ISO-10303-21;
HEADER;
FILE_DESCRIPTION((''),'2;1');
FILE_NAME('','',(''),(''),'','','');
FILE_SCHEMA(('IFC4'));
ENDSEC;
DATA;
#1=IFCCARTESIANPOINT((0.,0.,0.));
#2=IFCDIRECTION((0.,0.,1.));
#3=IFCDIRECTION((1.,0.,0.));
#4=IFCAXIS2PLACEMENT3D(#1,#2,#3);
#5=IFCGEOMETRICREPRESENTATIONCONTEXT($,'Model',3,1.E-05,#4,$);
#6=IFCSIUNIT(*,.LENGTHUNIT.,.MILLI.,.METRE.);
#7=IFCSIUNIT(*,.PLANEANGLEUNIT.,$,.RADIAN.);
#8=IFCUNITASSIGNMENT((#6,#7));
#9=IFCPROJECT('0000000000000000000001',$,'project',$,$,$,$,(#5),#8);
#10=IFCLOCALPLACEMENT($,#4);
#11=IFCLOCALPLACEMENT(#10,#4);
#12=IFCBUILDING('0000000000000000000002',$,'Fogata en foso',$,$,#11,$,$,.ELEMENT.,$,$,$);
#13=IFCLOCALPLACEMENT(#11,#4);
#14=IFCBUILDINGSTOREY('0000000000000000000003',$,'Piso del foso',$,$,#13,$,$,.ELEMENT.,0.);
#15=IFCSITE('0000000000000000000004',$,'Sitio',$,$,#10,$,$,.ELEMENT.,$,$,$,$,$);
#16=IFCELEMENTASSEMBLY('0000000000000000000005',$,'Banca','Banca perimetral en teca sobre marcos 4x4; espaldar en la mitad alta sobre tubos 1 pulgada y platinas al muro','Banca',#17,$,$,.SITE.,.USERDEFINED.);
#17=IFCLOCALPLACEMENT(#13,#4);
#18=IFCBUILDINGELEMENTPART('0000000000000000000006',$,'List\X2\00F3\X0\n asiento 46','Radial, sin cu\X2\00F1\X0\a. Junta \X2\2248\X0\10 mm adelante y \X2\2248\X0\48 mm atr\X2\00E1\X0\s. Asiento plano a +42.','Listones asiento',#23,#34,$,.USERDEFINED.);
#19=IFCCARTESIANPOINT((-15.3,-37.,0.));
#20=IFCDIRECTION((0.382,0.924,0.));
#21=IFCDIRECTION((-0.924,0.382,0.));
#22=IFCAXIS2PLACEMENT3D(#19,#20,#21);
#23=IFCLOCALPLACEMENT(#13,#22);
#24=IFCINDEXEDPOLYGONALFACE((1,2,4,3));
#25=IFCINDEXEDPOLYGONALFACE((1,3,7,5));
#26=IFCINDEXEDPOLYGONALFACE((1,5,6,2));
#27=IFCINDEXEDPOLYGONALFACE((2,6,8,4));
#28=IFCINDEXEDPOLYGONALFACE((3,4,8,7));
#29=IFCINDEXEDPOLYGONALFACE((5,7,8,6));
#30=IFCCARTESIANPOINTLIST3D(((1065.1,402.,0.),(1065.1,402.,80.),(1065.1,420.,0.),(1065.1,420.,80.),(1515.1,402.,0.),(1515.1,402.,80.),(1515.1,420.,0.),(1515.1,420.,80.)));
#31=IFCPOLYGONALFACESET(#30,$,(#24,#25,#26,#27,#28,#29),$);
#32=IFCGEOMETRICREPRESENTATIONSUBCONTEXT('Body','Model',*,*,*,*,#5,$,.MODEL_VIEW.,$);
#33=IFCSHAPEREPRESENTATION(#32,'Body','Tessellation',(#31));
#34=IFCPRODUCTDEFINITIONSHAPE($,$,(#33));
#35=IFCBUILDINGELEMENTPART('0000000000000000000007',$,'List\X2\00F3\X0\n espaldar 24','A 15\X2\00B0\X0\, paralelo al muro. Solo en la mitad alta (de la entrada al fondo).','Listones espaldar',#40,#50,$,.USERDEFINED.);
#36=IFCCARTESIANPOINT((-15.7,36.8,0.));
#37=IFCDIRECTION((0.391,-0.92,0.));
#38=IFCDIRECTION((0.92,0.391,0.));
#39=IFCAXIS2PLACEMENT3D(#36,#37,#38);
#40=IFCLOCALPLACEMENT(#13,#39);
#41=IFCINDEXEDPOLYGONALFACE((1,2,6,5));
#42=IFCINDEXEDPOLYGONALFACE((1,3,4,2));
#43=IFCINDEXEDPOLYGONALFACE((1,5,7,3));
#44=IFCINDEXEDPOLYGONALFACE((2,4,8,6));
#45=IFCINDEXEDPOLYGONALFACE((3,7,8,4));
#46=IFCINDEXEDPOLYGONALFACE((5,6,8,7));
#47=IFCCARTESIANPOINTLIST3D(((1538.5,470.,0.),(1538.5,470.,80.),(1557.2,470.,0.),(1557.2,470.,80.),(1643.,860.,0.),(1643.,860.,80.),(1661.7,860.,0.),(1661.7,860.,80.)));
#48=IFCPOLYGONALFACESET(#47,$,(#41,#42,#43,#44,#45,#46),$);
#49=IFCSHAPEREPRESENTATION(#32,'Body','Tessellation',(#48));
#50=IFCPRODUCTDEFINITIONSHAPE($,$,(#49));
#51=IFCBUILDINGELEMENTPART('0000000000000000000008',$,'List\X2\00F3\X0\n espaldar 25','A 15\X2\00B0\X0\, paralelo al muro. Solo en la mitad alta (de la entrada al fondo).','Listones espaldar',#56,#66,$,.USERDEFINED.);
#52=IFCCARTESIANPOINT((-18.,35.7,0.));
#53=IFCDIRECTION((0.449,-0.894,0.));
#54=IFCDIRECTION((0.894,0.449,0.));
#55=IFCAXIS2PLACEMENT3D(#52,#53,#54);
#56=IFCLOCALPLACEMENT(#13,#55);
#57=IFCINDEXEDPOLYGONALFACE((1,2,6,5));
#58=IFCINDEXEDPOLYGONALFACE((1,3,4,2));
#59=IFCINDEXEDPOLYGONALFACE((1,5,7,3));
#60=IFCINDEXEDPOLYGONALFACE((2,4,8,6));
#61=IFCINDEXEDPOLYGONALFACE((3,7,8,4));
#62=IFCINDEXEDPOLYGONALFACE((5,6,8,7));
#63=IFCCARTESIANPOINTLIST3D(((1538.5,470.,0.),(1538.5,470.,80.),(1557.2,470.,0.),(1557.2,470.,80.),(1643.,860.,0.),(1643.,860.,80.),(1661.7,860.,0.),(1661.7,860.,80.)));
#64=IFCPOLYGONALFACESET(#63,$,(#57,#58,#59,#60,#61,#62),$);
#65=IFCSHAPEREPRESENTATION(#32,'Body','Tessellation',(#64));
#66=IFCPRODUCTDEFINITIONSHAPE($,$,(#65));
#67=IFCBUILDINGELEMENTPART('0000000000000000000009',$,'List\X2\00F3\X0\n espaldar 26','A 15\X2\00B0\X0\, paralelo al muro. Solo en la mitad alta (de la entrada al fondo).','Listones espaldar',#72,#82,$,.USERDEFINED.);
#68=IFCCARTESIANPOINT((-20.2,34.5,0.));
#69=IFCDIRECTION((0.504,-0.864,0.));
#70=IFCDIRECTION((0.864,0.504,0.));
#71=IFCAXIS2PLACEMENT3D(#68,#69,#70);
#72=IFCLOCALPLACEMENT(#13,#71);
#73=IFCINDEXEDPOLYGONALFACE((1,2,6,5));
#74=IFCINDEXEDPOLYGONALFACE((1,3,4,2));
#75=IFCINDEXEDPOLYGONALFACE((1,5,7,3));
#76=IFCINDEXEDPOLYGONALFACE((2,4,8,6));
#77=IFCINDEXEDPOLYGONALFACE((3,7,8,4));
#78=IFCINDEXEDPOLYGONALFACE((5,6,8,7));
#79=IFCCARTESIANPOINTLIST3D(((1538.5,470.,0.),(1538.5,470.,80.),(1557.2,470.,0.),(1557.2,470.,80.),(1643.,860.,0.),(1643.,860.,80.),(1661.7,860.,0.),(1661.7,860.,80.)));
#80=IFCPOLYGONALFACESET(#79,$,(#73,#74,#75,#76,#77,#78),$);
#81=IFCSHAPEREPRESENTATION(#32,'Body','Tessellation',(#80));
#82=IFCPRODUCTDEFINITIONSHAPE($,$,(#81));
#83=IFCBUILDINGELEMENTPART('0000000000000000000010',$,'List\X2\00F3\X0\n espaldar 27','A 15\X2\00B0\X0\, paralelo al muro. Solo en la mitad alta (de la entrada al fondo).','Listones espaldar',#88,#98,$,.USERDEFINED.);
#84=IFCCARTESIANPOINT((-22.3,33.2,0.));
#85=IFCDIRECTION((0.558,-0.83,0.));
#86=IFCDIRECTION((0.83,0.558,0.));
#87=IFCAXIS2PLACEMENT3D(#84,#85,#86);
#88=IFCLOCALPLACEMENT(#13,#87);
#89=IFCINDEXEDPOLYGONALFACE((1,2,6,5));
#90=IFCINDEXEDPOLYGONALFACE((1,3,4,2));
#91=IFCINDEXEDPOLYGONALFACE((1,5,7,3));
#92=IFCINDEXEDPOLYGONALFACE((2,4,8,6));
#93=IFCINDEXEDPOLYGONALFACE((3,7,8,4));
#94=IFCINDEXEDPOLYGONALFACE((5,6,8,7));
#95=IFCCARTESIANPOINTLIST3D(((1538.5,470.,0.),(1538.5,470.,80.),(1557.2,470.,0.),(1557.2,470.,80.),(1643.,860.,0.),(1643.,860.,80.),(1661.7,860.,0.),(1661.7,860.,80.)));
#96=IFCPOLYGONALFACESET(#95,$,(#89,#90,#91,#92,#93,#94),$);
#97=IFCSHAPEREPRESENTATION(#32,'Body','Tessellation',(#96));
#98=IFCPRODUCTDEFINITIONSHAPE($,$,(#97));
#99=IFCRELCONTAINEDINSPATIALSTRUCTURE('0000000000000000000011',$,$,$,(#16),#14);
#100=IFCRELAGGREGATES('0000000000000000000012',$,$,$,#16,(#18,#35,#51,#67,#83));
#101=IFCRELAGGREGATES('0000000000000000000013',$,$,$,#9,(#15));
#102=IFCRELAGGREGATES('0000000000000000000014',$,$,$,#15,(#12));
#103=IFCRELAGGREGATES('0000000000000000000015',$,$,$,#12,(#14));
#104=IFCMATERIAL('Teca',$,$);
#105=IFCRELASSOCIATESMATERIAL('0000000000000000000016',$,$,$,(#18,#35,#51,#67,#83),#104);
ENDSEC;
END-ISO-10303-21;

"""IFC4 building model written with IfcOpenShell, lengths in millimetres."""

from ifc_helpers import new_model, si_unit, frame, origin_with_axes, place, context, subcontext, project, spatial, polyline, outline, extrude, material, element, aggregate, save


model = new_model("IFC4")

# Units and contexts
model_context = context("Model", 3, precision=1e-05, world=origin_with_axes())
body_context = subcontext(model_context, "Body", "Model", "MODEL_VIEW")
ifc_project = project(units=[si_unit("LENGTHUNIT", "METRE", prefix="MILLI"), si_unit("PLANEANGLEUNIT", "RADIAN")], contexts=[model_context])

# Site, building, storey
site_placement = place(None, origin_with_axes())
site = spatial("IfcSite", under=ifc_project, at=site_placement, Name="Sitio", CompositionType="ELEMENT")
building_placement = place(site_placement, origin_with_axes())
building = spatial("IfcBuilding", under=site, at=building_placement, Name="Fogata en foso", CompositionType="ELEMENT")
storey_placement = place(building_placement, origin_with_axes())
storey = spatial("IfcBuildingStorey", under=building, at=storey_placement, Name="Piso del foso", CompositionType="ELEMENT", Elevation=0.0)

# Element assembly, building element parts
assembly_placement = place(storey_placement, origin_with_axes())
assembly = element("IfcElementAssembly", 1, at=assembly_placement, inside=storey, Name="Banca", Description="Banca perimetral en teca sobre marcos 4x4; espaldar en la mitad alta sobre tubos 1 pulgada y platinas al muro", ObjectType="Banca", AssemblyPlace="SITE", PredefinedType="USERDEFINED")
ifc_material_1 = material(Name="Teca")
building_element_part_1_placement = place(storey_placement, frame((-15.3, -37.0, 0.0), z_axis=(0.382, 0.924, 0.0), x_axis=(-0.924, 0.382, 0.0)))
building_element_part_1 = element("IfcBuildingElementPart", 2, at=building_element_part_1_placement, material=ifc_material_1, Name="Listón asiento 46", Description="Radial, sin cuña. Junta ≈10 mm adelante y ≈48 mm atrás. Asiento plano a +42.", ObjectType="Listones asiento", PredefinedType="USERDEFINED", context=body_context, shape_type="SweptSolid", body=[
    extrude(outline(polyline([(1065.1, 402.0), (1515.1, 402.0), (1515.1, 420.0), (1065.1, 420.0), (1065.1, 402.0)])), origin_with_axes(), (0.0, 0.0, 1.0), 80.0),
])
building_element_part_2_placement = place(storey_placement, frame((-15.7, 36.8, 0.0), z_axis=(0.391, -0.92, 0.0), x_axis=(0.92, 0.391, 0.0)))
building_element_part_2 = element("IfcBuildingElementPart", 3, at=building_element_part_2_placement, material=ifc_material_1, Name="Listón espaldar 24", Description="A 15°, paralelo al muro. Solo en la mitad alta (de la entrada al fondo).", ObjectType="Listones espaldar", PredefinedType="USERDEFINED", context=body_context, shape_type="SweptSolid", body=[
    extrude(outline(polyline([(1538.5, 470.0), (1557.2, 470.0), (1661.7, 860.0), (1643.0, 860.0), (1538.5, 470.0)])), origin_with_axes(), (0.0, 0.0, 1.0), 80.0),
])
building_element_part_3_placement = place(storey_placement, frame((-18.0, 35.7, 0.0), z_axis=(0.449, -0.894, 0.0), x_axis=(0.894, 0.449, 0.0)))
building_element_part_3 = element("IfcBuildingElementPart", 4, at=building_element_part_3_placement, material=ifc_material_1, Name="Listón espaldar 25", Description="A 15°, paralelo al muro. Solo en la mitad alta (de la entrada al fondo).", ObjectType="Listones espaldar", PredefinedType="USERDEFINED", context=body_context, shape_type="SweptSolid", body=[
    extrude(outline(polyline([(1538.5, 470.0), (1557.2, 470.0), (1661.7, 860.0), (1643.0, 860.0), (1538.5, 470.0)])), origin_with_axes(), (0.0, 0.0, 1.0), 80.0),
])
building_element_part_4_placement = place(storey_placement, frame((-20.2, 34.5, 0.0), z_axis=(0.504, -0.864, 0.0), x_axis=(0.864, 0.504, 0.0)))
building_element_part_4 = element("IfcBuildingElementPart", 5, at=building_element_part_4_placement, material=ifc_material_1, Name="Listón espaldar 26", Description="A 15°, paralelo al muro. Solo en la mitad alta (de la entrada al fondo).", ObjectType="Listones espaldar", PredefinedType="USERDEFINED", context=body_context, shape_type="SweptSolid", body=[
    extrude(outline(polyline([(1538.5, 470.0), (1557.2, 470.0), (1661.7, 860.0), (1643.0, 860.0), (1538.5, 470.0)])), origin_with_axes(), (0.0, 0.0, 1.0), 80.0),
])
building_element_part_5_placement = place(storey_placement, frame((-22.3, 33.2, 0.0), z_axis=(0.558, -0.83, 0.0), x_axis=(0.83, 0.558, 0.0)))
building_element_part_5 = element("IfcBuildingElementPart", 6, at=building_element_part_5_placement, material=ifc_material_1, Name="Listón espaldar 27", Description="A 15°, paralelo al muro. Solo en la mitad alta (de la entrada al fondo).", ObjectType="Listones espaldar", PredefinedType="USERDEFINED", context=body_context, shape_type="SweptSolid", body=[
    extrude(outline(polyline([(1538.5, 470.0), (1557.2, 470.0), (1661.7, 860.0), (1643.0, 860.0), (1538.5, 470.0)])), origin_with_axes(), (0.0, 0.0, 1.0), 80.0),
])
aggregate(assembly, [building_element_part_1, building_element_part_2, building_element_part_3, building_element_part_4, building_element_part_5])

save(model, "model.ifc")
